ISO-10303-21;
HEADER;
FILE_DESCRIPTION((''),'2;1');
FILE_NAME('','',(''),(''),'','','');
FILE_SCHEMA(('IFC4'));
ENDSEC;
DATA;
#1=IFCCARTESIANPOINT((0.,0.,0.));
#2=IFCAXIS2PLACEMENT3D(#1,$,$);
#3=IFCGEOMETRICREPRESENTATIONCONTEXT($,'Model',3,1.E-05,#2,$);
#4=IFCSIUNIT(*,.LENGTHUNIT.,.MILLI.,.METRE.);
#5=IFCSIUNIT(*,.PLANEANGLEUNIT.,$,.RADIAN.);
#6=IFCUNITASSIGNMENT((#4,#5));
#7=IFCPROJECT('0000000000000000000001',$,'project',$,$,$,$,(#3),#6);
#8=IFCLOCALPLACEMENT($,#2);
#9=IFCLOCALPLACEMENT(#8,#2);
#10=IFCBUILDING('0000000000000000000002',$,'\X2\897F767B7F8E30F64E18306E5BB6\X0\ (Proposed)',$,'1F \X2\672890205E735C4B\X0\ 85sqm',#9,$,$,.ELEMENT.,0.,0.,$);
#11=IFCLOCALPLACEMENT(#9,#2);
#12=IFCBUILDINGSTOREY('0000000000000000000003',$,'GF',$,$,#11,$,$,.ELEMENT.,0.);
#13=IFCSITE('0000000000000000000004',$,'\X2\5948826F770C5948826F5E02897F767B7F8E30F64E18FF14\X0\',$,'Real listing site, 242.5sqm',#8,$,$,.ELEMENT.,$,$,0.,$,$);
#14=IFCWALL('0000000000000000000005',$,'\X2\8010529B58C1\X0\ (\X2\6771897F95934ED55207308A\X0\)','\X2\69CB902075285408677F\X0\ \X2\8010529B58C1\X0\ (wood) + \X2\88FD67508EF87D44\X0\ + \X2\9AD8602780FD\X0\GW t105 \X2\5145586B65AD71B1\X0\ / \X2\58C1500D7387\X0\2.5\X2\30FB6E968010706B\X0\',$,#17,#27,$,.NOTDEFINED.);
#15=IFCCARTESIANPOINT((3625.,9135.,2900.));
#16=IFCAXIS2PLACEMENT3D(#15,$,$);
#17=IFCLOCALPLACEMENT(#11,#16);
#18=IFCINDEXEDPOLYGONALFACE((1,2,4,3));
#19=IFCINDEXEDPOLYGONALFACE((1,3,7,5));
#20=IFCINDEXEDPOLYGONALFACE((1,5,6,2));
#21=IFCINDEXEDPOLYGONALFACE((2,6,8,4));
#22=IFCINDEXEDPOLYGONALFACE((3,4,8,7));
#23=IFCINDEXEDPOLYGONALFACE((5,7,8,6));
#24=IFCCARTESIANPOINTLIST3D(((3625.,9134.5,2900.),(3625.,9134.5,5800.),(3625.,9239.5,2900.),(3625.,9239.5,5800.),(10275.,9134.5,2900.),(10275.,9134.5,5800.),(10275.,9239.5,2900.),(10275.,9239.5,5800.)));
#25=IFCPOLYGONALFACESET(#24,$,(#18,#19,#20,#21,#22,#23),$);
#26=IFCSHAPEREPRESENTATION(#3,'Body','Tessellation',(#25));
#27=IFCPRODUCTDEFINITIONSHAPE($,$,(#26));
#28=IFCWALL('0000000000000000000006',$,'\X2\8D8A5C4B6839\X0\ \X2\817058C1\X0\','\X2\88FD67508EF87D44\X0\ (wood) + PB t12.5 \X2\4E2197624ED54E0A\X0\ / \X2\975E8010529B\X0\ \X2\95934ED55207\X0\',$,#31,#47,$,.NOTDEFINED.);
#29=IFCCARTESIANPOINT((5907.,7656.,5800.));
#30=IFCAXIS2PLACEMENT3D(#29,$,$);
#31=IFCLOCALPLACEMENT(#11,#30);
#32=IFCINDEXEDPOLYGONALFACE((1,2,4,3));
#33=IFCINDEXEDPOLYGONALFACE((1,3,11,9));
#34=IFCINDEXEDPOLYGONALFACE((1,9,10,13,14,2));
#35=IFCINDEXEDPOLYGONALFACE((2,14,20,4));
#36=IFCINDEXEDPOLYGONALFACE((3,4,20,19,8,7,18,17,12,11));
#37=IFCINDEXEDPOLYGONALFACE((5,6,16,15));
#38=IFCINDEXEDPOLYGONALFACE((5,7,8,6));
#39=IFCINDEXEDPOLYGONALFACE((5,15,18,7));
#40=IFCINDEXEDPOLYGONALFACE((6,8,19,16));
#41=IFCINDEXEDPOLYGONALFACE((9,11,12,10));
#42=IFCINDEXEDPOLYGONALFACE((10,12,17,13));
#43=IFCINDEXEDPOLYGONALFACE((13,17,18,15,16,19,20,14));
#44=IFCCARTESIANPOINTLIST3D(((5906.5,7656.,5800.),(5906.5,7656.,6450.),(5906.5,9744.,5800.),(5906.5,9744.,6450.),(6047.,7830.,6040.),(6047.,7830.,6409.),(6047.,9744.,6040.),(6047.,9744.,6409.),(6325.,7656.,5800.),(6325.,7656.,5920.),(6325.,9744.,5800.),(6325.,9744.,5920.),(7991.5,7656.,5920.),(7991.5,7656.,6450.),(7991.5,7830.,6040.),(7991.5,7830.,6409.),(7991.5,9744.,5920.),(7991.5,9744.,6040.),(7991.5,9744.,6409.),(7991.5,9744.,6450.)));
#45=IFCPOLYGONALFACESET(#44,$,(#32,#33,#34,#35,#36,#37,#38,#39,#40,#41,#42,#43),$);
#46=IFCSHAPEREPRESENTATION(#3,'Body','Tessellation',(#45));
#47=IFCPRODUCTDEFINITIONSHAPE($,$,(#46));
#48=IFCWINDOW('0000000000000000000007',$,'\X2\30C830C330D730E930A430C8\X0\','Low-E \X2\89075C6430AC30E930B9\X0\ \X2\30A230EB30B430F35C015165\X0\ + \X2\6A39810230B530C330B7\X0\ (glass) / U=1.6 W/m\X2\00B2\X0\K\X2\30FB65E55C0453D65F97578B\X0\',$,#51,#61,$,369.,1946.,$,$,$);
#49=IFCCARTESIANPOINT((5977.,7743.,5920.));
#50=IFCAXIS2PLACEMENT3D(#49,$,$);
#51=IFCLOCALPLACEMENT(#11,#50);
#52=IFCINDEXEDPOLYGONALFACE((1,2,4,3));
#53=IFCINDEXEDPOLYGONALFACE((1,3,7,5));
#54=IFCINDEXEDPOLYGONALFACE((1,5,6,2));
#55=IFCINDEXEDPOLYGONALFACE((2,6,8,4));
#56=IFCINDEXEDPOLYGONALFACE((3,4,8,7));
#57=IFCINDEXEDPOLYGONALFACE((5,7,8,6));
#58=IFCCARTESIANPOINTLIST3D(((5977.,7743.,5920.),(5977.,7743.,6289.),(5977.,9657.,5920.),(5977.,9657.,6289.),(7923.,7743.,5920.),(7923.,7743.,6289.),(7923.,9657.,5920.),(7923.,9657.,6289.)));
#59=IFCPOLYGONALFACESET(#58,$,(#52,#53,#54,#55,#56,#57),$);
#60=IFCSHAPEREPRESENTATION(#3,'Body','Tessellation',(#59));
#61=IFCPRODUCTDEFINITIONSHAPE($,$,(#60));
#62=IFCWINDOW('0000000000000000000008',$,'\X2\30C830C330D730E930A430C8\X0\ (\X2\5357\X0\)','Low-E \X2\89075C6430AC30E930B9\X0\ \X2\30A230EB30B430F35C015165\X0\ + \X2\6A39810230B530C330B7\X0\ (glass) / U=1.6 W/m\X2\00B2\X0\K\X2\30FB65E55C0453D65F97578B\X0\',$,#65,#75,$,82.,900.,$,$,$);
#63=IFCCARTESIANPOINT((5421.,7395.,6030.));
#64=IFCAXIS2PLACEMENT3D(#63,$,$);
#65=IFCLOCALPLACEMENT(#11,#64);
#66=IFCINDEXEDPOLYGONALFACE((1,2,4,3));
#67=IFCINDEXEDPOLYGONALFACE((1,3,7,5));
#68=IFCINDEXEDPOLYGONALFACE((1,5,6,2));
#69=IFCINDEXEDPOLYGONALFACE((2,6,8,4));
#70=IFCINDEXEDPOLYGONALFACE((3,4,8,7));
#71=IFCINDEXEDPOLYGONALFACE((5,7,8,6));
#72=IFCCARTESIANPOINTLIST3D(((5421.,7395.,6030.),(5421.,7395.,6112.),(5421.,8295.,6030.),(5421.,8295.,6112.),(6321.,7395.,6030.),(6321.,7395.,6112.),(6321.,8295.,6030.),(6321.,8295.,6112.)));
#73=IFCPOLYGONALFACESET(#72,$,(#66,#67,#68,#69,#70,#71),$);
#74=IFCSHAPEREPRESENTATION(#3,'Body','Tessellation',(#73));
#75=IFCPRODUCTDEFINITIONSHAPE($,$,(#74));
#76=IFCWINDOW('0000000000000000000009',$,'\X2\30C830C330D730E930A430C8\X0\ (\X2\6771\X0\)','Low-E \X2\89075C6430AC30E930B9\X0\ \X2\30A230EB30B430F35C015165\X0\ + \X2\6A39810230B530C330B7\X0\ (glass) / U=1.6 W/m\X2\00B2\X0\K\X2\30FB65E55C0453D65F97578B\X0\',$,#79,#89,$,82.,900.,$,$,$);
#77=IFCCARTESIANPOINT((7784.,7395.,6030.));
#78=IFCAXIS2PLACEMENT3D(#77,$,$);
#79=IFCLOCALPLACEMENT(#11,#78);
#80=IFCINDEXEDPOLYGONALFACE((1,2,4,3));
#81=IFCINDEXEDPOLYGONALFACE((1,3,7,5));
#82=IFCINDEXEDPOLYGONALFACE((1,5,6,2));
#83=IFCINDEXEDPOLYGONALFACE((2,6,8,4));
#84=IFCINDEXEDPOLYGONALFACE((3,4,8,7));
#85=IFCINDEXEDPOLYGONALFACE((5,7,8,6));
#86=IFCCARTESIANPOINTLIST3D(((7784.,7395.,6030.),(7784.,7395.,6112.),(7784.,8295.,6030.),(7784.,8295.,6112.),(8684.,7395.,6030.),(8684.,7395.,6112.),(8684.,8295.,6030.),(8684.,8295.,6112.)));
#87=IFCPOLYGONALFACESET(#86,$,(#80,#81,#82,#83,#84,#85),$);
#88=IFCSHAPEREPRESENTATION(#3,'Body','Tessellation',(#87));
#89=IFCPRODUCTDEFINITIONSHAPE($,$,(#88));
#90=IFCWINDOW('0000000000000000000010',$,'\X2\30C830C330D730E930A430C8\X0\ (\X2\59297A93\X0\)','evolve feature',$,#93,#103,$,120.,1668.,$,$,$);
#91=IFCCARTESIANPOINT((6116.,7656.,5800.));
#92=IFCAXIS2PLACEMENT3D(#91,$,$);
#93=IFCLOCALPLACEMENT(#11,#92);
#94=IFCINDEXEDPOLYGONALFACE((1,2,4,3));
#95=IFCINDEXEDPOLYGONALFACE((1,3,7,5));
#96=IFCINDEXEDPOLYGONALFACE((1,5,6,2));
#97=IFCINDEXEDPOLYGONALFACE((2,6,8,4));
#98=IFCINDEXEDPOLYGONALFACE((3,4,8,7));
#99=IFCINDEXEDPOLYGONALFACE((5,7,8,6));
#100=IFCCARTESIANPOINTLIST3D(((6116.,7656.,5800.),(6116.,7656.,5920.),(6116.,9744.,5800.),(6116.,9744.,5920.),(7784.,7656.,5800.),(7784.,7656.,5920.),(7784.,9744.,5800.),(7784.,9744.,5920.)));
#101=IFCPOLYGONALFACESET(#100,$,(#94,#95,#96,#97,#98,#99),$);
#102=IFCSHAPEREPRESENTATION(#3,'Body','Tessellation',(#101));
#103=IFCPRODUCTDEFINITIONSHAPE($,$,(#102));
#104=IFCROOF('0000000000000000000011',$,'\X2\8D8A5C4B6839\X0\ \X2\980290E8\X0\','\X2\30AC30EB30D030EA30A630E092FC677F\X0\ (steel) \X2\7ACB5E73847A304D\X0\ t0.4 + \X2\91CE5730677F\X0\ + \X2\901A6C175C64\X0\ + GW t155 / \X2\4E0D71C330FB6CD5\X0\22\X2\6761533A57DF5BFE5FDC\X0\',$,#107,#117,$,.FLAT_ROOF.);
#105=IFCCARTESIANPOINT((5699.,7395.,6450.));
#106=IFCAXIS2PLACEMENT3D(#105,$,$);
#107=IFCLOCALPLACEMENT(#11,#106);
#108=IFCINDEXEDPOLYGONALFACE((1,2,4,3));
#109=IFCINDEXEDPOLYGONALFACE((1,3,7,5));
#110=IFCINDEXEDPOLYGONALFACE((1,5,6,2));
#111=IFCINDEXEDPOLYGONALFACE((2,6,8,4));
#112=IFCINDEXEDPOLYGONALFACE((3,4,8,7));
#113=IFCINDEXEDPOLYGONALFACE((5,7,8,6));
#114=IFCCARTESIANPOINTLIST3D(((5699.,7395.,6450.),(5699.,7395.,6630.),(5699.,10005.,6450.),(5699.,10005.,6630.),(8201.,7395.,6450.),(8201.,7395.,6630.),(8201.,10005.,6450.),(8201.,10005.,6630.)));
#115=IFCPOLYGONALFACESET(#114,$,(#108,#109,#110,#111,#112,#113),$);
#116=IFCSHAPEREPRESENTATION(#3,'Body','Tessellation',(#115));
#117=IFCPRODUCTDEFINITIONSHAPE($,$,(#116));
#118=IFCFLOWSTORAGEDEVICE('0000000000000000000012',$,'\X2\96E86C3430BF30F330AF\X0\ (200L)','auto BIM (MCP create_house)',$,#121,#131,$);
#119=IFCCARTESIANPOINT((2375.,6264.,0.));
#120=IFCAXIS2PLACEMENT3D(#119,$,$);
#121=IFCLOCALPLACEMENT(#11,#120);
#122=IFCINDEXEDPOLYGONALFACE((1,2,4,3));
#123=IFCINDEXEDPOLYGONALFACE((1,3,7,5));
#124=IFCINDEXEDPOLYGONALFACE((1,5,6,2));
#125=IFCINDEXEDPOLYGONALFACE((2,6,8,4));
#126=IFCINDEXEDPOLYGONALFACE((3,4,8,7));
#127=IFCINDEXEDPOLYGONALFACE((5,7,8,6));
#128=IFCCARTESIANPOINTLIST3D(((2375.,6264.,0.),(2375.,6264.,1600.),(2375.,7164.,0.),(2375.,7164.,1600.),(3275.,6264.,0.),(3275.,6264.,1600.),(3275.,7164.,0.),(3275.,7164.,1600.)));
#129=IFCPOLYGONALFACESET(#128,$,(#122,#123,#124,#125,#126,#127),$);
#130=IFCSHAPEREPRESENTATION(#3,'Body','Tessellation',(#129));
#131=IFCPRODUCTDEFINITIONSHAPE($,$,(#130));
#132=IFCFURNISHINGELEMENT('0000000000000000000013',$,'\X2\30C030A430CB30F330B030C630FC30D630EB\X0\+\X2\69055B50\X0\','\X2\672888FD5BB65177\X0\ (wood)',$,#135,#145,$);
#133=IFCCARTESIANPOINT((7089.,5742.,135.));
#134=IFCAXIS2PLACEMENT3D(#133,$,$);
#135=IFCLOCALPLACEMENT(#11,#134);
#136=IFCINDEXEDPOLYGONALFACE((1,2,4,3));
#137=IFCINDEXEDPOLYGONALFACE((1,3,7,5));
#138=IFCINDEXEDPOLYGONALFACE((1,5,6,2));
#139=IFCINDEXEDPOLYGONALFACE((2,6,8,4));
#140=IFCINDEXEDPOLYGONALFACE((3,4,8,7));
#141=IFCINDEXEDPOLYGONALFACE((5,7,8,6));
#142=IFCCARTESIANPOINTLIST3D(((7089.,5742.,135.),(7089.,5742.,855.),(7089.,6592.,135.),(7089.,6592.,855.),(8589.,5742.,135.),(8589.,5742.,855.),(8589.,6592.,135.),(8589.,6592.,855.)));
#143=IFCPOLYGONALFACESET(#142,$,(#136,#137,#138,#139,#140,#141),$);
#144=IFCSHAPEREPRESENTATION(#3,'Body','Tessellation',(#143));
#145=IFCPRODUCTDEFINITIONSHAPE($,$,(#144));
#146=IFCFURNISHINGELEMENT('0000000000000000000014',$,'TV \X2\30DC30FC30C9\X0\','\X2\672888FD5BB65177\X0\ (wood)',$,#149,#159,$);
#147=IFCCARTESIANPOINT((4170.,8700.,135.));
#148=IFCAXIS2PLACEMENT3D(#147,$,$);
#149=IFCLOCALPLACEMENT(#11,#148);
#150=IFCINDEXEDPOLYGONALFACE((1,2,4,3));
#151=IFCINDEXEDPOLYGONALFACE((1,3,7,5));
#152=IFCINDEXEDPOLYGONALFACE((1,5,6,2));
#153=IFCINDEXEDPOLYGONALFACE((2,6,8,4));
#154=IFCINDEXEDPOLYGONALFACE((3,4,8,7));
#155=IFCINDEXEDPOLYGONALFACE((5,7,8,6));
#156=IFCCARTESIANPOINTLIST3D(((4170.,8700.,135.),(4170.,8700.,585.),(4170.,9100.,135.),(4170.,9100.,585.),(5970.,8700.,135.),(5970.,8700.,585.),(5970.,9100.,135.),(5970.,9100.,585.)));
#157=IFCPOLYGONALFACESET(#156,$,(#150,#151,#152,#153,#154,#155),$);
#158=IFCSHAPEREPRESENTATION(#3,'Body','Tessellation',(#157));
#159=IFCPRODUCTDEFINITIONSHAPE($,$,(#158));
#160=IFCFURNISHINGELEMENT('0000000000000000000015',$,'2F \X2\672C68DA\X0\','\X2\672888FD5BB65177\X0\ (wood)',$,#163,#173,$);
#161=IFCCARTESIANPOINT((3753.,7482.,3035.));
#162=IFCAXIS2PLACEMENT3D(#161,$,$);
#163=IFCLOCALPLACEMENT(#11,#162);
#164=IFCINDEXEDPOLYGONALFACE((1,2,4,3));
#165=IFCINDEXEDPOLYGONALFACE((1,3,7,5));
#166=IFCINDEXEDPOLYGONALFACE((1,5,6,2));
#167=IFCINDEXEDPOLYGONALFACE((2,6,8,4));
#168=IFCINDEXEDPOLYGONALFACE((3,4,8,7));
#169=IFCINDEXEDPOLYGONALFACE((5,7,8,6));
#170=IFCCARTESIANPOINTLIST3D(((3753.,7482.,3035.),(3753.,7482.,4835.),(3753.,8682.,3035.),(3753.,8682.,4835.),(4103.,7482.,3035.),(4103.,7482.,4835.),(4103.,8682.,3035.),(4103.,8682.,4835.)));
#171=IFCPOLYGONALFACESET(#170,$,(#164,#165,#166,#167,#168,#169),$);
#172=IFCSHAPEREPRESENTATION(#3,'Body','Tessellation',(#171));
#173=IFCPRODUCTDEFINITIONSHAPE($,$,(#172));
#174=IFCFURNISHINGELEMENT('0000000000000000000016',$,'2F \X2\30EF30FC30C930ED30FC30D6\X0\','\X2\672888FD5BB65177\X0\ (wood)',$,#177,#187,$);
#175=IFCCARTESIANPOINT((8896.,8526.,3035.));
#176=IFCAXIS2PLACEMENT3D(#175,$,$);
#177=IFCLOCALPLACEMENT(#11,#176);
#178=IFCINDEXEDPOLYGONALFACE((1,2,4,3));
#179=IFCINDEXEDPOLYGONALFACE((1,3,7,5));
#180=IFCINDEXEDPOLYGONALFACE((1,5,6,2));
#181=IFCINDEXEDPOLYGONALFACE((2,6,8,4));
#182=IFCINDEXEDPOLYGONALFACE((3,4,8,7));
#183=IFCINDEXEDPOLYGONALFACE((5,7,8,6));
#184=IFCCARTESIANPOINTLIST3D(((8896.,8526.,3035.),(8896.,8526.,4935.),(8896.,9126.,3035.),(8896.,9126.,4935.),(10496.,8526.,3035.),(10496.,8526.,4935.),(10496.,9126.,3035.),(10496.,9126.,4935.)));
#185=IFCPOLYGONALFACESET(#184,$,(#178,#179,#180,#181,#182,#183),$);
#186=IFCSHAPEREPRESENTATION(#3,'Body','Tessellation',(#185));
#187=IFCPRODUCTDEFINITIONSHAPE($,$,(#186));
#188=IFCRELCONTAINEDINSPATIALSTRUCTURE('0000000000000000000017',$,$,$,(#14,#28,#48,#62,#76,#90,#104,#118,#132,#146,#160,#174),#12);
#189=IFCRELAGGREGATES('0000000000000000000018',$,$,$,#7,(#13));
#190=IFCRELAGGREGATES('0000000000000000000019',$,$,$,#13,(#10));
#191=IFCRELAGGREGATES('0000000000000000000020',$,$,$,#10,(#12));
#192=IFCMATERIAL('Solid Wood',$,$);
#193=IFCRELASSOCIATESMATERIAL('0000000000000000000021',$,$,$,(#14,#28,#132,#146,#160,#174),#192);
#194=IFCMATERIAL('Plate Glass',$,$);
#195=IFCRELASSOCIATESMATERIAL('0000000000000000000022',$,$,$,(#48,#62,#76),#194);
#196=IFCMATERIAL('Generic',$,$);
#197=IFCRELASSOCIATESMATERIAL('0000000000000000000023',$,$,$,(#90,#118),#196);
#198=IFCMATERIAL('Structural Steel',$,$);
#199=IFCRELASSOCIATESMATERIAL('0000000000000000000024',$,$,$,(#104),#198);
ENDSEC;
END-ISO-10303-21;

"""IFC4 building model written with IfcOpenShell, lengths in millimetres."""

from ifc_helpers import new_model, si_unit, frame, frame_2d, origin, place, context, project, spatial, rectangle, extrude, material, element, fill, save


model = new_model("IFC4")

# Units and contexts
model_context = context("Model", 3, precision=1e-05, world=origin())
ifc_project = project(units=[si_unit("LENGTHUNIT", "METRE", prefix="MILLI"), si_unit("PLANEANGLEUNIT", "RADIAN")], contexts=[model_context])

# Site, building, storey
site_placement = place(None, origin())
site = spatial("IfcSite", under=ifc_project, at=site_placement, Name="奈良県奈良市西登美ヶ丘４", ObjectType="Real listing site, 242.5sqm", CompositionType="ELEMENT", RefElevation=0.0)
building_placement = place(site_placement, origin())
building = spatial("IfcBuilding", under=site, at=building_placement, Name="西登美ヶ丘の家 (Proposed)", ObjectType="1F 木造平屋 85sqm", CompositionType="ELEMENT", ElevationOfRefHeight=0.0, ElevationOfTerrain=0.0)
storey_placement = place(building_placement, origin())
storey = spatial("IfcBuildingStorey", under=building, at=storey_placement, Name="GF", CompositionType="ELEMENT", Elevation=0.0)

# Wall
ifc_material_1 = material(Name="Solid Wood")
wall_1_placement = place(storey_placement, frame((3625.0, 9135.0, 2900.0)))
element("IfcWall", 1, at=wall_1_placement, inside=storey, material=ifc_material_1, Name="耐力壁 (東西間仕切り)", Description="構造用合板 耐力壁 (wood) + 製材軸組 + 高性能GW t105 充填断熱 / 壁倍率2.5・準耐火", PredefinedType="NOTDEFINED", context=model_context, shape_type="SweptSolid", body=[
    extrude(rectangle(XDim=6650.0, YDim=105.0, at=frame_2d((3325.0, 52.0))), frame((3625.0, 9135.0, 2900.0)), (0.0, 0.0, 1.0), 2900.0),
])

# Wall, openings, windows
wall_2_placement = place(storey_placement, frame((5907.0, 7656.0, 5800.0)))
wall_2 = element("IfcWall", 2, at=wall_2_placement, inside=storey, material=ifc_material_1, Name="越屋根 腰壁", Description="製材軸組 (wood) + PB t12.5 両面仕上 / 非耐力 間仕切", PredefinedType="NOTDEFINED", context=model_context, shape_type="SweptSolid", body=[
    extrude(rectangle(XDim=2085.0, YDim=2088.0, at=frame_2d((1042.0, 1044.0))), frame((5907.0, 7656.0, 5800.0)), (0.0, 0.0, 1.0), 650.0),
])
opening_1_placement = place(storey_placement, frame((5977.0, 7743.0, 5920.0)))
opening_1 = element("IfcOpeningElement", 3, at=opening_1_placement, cuts=wall_2, PredefinedType="NOTDEFINED", context=model_context, shape_type="SweptSolid", body=[
    extrude(rectangle(XDim=1946.0, YDim=1914.0, at=frame_2d((973.0, 957.0))), frame((5977.0, 7743.0, 5920.0)), (0.0, 0.0, 1.0), 369.0),
])
opening_2_placement = place(storey_placement, frame((5421.0, 7395.0, 6030.0)))
opening_2 = element("IfcOpeningElement", 4, at=opening_2_placement, cuts=wall_2, PredefinedType="NOTDEFINED", context=model_context, shape_type="SweptSolid", body=[
    extrude(rectangle(XDim=900.0, YDim=900.0, at=frame_2d((450.0, 450.0))), frame((5421.0, 7395.0, 6030.0)), (0.0, 0.0, 1.0), 82.0),
])
opening_3_placement = place(storey_placement, frame((7784.0, 7395.0, 6030.0)))
opening_3 = element("IfcOpeningElement", 5, at=opening_3_placement, cuts=wall_2, PredefinedType="NOTDEFINED", context=model_context, shape_type="SweptSolid", body=[
    extrude(rectangle(XDim=900.0, YDim=900.0, at=frame_2d((450.0, 450.0))), frame((7784.0, 7395.0, 6030.0)), (0.0, 0.0, 1.0), 82.0),
])
opening_4_placement = place(storey_placement, frame((6116.0, 7656.0, 5800.0)))
opening_4 = element("IfcOpeningElement", 6, at=opening_4_placement, cuts=wall_2, PredefinedType="NOTDEFINED", context=model_context, shape_type="SweptSolid", body=[
    extrude(rectangle(XDim=1668.0, YDim=2088.0, at=frame_2d((834.0, 1044.0))), frame((6116.0, 7656.0, 5800.0)), (0.0, 0.0, 1.0), 120.0),
])
ifc_material_2 = material(Name="Plate Glass")
window_1_placement = place(storey_placement, frame((5977.0, 7743.0, 5920.0)))
window_1 = element("IfcWindow", 7, at=window_1_placement, inside=storey, material=ifc_material_2, Name="トップライト", Description="Low-E 複層ガラス アルゴン封入 + 樹脂サッシ (glass) / U=1.6 W/m²K・日射取得型", OverallHeight=369.0, OverallWidth=1946.0, context=model_context, shape_type="SweptSolid", body=[
    extrude(rectangle(XDim=1946.0, YDim=1914.0, at=frame_2d((973.0, 957.0))), frame((5977.0, 7743.0, 5920.0)), (0.0, 0.0, 1.0), 369.0),
])
fill(opening_1, window_1)
window_2_placement = place(storey_placement, frame((5421.0, 7395.0, 6030.0)))
window_2 = element("IfcWindow", 8, at=window_2_placement, inside=storey, material=ifc_material_2, Name="トップライト (南)", Description="Low-E 複層ガラス アルゴン封入 + 樹脂サッシ (glass) / U=1.6 W/m²K・日射取得型", OverallHeight=82.0, OverallWidth=900.0, context=model_context, shape_type="SweptSolid", body=[
    extrude(rectangle(XDim=900.0, YDim=900.0, at=frame_2d((450.0, 450.0))), frame((5421.0, 7395.0, 6030.0)), (0.0, 0.0, 1.0), 82.0),
])
fill(opening_2, window_2)
window_3_placement = place(storey_placement, frame((7784.0, 7395.0, 6030.0)))
window_3 = element("IfcWindow", 9, at=window_3_placement, inside=storey, material=ifc_material_2, Name="トップライト (東)", Description="Low-E 複層ガラス アルゴン封入 + 樹脂サッシ (glass) / U=1.6 W/m²K・日射取得型", OverallHeight=82.0, OverallWidth=900.0, context=model_context, shape_type="SweptSolid", body=[
    extrude(rectangle(XDim=900.0, YDim=900.0, at=frame_2d((450.0, 450.0))), frame((7784.0, 7395.0, 6030.0)), (0.0, 0.0, 1.0), 82.0),
])
fill(opening_3, window_3)
ifc_material_3 = material(Name="Generic")
window_4_placement = place(storey_placement, frame((6116.0, 7656.0, 5800.0)))
window_4 = element("IfcWindow", 10, at=window_4_placement, inside=storey, material=ifc_material_3, Name="トップライト (天窓)", Description="evolve feature", OverallHeight=120.0, OverallWidth=1668.0, context=model_context, shape_type="SweptSolid", body=[
    extrude(rectangle(XDim=1668.0, YDim=2088.0, at=frame_2d((834.0, 1044.0))), frame((6116.0, 7656.0, 5800.0)), (0.0, 0.0, 1.0), 120.0),
])
fill(opening_4, window_4)

# Roof
ifc_material_4 = material(Name="Structural Steel")
roof_placement = place(storey_placement, frame((5699.0, 7395.0, 6450.0)))
element("IfcRoof", 11, at=roof_placement, inside=storey, material=ifc_material_4, Name="越屋根 頂部", Description="ガルバリウム鋼板 (steel) 立平葺き t0.4 + 野地板 + 通気層 + GW t155 / 不燃・法22条区域対応", PredefinedType="FLAT_ROOF", context=model_context, shape_type="SweptSolid", body=[
    extrude(rectangle(XDim=2502.0, YDim=2610.0, at=frame_2d((1251.0, 1305.0))), frame((5699.0, 7395.0, 6450.0)), (0.0, 0.0, 1.0), 180.0),
])

# Flow storage device
flow_storage_device_placement = place(storey_placement, frame((2375.0, 6264.0, 0.0)))
element("IfcFlowStorageDevice", 12, at=flow_storage_device_placement, inside=storey, material=ifc_material_3, Name="雨水タンク (200L)", Description="auto BIM (MCP create_house)", context=model_context, shape_type="SweptSolid", body=[
    extrude(rectangle(XDim=900.0, YDim=900.0, at=frame_2d((450.0, 450.0))), frame((2375.0, 6264.0, 0.0)), (0.0, 0.0, 1.0), 1600.0),
])

# Furnishing elements
furnishing_1_placement = place(storey_placement, frame((7089.0, 5742.0, 135.0)))
element("IfcFurnishingElement", 13, at=furnishing_1_placement, inside=storey, material=ifc_material_1, Name="ダイニングテーブル+椅子", Description="木製家具 (wood)", context=model_context, shape_type="SweptSolid", body=[
    extrude(rectangle(XDim=1500.0, YDim=850.0, at=frame_2d((750.0, 425.0))), frame((7089.0, 5742.0, 135.0)), (0.0, 0.0, 1.0), 720.0),
])
furnishing_2_placement = place(storey_placement, frame((4170.0, 8700.0, 135.0)))
element("IfcFurnishingElement", 14, at=furnishing_2_placement, inside=storey, material=ifc_material_1, Name="TV ボード", Description="木製家具 (wood)", context=model_context, shape_type="SweptSolid", body=[
    extrude(rectangle(XDim=1800.0, YDim=400.0, at=frame_2d((900.0, 200.0))), frame((4170.0, 8700.0, 135.0)), (0.0, 0.0, 1.0), 450.0),
])
furnishing_3_placement = place(storey_placement, frame((3753.0, 7482.0, 3035.0)))
element("IfcFurnishingElement", 15, at=furnishing_3_placement, inside=storey, material=ifc_material_1, Name="2F 本棚", Description="木製家具 (wood)", context=model_context, shape_type="SweptSolid", body=[
    extrude(rectangle(XDim=350.0, YDim=1200.0, at=frame_2d((175.0, 600.0))), frame((3753.0, 7482.0, 3035.0)), (0.0, 0.0, 1.0), 1800.0),
])
furnishing_4_placement = place(storey_placement, frame((8896.0, 8526.0, 3035.0)))
element("IfcFurnishingElement", 16, at=furnishing_4_placement, inside=storey, material=ifc_material_1, Name="2F ワードローブ", Description="木製家具 (wood)", context=model_context, shape_type="SweptSolid", body=[
    extrude(rectangle(XDim=1600.0, YDim=600.0, at=frame_2d((800.0, 300.0))), frame((8896.0, 8526.0, 3035.0)), (0.0, 0.0, 1.0), 1900.0),
])

save(model, "model.ifc")
